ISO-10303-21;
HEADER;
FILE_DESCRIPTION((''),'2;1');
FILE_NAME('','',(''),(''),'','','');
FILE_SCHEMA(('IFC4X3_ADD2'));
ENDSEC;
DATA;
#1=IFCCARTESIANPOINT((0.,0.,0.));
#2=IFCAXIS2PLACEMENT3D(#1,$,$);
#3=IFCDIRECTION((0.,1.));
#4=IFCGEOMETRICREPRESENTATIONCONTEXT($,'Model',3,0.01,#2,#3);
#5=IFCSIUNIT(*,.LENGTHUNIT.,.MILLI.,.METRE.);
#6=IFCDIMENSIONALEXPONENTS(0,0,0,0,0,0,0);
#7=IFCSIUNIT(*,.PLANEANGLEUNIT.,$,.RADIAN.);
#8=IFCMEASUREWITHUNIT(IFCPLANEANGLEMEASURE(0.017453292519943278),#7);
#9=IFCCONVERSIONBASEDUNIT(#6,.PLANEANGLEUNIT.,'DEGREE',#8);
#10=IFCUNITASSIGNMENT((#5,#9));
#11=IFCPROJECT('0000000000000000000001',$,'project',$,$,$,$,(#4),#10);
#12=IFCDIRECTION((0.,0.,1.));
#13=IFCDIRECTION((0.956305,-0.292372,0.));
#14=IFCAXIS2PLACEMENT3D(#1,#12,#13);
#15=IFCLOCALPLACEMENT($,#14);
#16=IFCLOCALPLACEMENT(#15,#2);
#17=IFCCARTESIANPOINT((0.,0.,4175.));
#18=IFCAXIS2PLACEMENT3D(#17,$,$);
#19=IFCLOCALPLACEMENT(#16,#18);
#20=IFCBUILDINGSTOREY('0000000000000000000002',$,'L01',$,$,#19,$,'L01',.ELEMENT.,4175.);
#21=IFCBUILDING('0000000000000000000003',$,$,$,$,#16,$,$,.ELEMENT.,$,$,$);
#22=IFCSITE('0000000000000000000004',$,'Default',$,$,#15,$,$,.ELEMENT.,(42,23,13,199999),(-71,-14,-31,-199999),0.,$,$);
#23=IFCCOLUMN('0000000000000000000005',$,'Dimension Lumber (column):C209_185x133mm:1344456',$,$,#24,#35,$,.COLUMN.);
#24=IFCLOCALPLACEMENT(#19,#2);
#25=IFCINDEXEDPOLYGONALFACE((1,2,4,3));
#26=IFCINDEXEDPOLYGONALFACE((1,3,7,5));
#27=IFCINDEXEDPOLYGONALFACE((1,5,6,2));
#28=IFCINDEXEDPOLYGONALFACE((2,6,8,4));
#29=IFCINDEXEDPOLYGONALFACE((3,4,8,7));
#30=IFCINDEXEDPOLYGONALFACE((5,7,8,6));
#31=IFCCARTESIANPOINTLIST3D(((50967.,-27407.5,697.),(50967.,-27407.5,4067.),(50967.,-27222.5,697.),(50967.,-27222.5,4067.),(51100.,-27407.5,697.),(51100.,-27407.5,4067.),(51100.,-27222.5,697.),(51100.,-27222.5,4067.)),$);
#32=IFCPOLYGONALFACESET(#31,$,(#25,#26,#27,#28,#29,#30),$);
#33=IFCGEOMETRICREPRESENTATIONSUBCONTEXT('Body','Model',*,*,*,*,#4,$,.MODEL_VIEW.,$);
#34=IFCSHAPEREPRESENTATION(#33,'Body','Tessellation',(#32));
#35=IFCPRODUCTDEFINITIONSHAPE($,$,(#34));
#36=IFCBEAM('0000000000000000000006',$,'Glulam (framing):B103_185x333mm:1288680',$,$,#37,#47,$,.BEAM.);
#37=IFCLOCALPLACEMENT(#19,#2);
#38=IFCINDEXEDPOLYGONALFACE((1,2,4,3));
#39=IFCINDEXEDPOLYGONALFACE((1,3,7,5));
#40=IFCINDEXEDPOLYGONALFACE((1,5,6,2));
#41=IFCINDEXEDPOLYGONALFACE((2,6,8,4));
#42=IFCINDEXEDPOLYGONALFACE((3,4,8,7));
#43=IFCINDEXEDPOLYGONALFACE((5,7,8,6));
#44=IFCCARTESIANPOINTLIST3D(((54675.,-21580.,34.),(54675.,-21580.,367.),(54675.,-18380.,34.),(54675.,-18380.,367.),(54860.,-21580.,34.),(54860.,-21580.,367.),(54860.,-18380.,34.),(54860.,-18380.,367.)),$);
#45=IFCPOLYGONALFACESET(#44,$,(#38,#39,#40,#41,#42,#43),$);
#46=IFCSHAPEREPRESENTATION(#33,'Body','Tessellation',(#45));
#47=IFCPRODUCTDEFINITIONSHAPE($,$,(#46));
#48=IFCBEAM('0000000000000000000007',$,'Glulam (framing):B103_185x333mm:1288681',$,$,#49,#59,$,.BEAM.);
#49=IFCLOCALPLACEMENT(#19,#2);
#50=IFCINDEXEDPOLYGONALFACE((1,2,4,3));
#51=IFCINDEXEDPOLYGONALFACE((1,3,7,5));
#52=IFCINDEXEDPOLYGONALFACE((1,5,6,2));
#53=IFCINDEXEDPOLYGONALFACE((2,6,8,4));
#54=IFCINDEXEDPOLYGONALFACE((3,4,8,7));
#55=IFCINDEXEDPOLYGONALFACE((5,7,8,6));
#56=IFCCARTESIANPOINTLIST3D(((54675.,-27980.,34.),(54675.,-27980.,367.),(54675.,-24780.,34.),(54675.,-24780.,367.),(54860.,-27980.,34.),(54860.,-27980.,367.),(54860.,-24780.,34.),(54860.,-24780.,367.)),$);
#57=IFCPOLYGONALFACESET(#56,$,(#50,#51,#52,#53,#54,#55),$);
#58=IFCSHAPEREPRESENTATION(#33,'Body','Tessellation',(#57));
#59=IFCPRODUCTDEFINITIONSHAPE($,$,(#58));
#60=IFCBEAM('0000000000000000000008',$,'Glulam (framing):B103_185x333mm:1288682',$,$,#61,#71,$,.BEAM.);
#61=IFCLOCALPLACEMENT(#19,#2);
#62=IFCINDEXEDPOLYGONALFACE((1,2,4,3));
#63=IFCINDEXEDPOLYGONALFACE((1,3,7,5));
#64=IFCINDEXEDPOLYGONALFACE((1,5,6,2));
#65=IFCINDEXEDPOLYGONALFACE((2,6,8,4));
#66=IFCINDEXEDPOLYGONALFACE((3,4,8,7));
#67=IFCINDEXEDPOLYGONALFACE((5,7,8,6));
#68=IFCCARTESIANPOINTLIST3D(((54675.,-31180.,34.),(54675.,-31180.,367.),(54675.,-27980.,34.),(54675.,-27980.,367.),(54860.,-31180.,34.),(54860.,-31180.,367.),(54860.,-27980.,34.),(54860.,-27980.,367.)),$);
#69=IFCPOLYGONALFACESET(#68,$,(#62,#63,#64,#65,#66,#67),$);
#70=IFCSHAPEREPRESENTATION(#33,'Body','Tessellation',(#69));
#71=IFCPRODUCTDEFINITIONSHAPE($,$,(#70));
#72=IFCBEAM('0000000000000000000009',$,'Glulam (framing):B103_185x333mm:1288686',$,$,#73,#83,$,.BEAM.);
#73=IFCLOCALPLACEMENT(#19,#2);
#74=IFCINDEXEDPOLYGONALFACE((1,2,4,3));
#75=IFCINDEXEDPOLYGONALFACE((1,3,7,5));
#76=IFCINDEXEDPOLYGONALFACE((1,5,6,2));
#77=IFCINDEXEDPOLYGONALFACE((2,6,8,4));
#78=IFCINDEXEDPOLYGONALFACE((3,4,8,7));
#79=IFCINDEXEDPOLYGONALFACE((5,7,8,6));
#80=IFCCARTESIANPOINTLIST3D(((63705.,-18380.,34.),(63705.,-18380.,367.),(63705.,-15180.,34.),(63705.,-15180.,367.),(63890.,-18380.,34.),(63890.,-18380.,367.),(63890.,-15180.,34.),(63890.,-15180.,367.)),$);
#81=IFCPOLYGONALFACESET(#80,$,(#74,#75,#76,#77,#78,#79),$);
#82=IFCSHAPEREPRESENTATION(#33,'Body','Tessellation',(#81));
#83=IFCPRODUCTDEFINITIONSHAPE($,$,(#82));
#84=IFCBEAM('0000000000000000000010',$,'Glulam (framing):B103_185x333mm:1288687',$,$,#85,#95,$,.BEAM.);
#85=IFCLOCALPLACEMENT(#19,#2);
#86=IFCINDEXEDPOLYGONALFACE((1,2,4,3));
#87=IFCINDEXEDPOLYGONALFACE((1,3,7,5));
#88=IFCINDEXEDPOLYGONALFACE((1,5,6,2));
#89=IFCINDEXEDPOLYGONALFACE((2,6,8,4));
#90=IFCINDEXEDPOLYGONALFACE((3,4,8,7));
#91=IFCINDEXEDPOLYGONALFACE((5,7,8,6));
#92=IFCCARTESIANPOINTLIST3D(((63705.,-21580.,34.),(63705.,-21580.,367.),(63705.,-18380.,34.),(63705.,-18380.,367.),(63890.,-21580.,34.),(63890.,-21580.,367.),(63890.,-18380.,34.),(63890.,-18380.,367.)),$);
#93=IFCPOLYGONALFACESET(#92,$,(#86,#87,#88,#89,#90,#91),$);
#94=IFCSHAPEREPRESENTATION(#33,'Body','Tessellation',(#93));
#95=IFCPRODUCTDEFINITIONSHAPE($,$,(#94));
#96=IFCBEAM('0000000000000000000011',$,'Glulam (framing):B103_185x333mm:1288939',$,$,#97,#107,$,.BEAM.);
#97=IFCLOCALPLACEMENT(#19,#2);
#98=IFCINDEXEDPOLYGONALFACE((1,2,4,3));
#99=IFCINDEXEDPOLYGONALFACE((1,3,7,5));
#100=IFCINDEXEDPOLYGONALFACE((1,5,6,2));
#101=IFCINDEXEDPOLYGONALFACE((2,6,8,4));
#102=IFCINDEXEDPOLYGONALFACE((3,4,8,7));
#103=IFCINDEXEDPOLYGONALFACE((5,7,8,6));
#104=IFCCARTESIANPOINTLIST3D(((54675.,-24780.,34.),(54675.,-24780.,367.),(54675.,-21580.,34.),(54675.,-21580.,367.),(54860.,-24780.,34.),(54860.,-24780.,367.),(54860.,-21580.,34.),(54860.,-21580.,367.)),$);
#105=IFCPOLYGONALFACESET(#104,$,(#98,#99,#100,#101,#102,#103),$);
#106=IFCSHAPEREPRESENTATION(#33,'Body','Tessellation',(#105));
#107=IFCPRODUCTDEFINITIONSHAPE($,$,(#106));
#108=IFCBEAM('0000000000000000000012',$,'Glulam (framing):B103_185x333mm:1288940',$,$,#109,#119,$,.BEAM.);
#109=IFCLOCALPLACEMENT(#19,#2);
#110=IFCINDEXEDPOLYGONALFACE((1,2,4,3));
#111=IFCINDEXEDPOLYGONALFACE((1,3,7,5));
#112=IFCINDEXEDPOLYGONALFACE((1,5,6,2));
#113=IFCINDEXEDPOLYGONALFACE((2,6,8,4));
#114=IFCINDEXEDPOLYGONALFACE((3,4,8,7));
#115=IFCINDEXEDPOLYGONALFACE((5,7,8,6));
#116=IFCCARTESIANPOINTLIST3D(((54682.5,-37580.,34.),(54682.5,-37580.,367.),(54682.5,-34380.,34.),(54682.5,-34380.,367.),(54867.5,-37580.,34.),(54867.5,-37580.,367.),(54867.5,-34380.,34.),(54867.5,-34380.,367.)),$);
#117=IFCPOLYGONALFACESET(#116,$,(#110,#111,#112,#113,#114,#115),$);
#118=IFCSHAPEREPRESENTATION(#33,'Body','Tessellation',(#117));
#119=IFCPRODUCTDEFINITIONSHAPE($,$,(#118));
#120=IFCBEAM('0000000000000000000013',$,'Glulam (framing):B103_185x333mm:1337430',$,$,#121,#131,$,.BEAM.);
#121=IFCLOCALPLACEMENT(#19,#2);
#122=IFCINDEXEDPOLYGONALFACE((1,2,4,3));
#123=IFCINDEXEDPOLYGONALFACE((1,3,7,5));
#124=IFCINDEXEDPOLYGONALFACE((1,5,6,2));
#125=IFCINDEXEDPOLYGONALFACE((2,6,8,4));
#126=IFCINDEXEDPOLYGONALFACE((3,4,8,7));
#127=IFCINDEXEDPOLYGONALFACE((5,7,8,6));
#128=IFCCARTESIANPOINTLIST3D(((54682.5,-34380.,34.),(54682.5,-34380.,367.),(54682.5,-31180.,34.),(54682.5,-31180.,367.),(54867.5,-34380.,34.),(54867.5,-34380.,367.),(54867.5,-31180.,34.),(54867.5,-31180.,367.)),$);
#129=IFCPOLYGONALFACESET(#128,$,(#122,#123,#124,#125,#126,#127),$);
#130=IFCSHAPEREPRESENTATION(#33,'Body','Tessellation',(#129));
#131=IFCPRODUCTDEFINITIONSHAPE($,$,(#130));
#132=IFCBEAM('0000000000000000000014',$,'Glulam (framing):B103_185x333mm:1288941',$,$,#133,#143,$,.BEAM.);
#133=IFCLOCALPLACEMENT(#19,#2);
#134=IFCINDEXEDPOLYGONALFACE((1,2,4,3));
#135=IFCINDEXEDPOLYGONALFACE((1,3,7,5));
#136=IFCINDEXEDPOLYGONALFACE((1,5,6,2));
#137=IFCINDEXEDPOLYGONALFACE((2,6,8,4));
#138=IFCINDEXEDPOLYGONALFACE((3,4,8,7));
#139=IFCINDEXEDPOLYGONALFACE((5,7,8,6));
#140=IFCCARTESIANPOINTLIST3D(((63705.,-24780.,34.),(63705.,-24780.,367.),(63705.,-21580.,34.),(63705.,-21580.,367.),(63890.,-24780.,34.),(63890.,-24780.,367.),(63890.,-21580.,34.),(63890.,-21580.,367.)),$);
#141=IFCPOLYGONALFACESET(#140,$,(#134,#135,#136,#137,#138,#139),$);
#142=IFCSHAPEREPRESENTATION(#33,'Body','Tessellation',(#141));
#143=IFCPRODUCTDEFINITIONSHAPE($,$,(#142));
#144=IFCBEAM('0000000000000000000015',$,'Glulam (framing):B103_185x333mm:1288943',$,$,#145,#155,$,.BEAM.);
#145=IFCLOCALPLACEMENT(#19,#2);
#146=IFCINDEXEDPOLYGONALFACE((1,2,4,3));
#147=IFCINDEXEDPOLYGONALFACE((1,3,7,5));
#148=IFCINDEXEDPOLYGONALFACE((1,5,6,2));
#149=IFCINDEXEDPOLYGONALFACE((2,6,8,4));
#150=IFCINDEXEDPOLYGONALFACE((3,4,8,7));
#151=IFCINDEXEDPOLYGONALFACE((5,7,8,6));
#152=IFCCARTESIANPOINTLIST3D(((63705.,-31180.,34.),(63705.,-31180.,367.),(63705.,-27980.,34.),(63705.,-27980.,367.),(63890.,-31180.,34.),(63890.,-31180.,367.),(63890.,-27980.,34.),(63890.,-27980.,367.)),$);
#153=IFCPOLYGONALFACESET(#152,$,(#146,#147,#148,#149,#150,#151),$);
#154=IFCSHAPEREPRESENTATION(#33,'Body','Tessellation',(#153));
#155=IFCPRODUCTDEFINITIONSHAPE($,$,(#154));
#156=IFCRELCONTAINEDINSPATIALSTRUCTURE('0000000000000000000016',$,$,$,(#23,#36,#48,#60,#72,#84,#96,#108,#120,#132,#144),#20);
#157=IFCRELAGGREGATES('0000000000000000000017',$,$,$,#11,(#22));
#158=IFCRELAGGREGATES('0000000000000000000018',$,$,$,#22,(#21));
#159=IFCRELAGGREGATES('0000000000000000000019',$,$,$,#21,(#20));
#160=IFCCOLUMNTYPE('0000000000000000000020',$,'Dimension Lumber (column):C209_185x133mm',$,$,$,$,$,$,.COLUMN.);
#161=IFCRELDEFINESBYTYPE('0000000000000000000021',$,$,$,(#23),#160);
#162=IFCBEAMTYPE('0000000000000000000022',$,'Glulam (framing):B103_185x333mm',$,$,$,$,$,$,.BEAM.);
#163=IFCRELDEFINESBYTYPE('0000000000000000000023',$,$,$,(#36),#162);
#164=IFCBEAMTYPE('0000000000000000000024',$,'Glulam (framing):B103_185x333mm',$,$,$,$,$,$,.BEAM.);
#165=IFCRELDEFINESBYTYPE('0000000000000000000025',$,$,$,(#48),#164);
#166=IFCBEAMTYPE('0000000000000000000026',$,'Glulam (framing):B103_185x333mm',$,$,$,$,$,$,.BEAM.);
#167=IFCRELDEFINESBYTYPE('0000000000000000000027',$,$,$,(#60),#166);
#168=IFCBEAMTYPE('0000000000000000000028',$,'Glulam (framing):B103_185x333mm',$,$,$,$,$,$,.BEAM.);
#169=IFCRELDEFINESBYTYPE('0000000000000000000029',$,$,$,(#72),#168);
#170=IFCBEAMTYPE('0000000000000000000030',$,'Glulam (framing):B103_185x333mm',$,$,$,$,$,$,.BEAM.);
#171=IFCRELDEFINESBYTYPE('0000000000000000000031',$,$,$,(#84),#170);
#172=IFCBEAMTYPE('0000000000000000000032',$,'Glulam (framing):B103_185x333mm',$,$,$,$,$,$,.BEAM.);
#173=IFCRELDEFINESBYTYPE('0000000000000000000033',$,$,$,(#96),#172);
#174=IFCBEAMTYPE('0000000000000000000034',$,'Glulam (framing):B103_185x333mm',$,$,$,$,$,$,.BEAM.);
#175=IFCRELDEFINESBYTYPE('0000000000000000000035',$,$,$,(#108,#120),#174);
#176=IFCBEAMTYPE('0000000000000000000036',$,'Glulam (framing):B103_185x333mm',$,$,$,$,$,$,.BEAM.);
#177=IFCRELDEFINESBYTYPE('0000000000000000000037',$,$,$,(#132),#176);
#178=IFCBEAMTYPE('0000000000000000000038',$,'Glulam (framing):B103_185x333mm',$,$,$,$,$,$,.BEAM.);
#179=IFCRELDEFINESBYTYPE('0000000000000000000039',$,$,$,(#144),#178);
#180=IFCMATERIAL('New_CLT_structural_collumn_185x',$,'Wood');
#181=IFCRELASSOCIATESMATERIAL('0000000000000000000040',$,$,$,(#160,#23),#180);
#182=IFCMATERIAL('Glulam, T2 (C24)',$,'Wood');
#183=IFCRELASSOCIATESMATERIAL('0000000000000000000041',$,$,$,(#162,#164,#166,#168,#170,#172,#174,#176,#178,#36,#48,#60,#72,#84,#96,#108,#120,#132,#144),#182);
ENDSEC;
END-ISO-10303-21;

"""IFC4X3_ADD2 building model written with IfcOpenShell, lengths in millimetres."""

from ifc_helpers import new_model, entity, si_unit, converted_unit, direction, frame, origin, origin_2d_with_axis, place, context, subcontext, project, spatial, rectangle, extrude, source, transform, mapped, material, material_profile, profile_set, profile_usage, type_object, type_shapes, element, save


model = new_model("IFC4X3_ADD2")

# Units and contexts
model_context = context("Model", 3, precision=0.01, world=origin(), true_north=direction((0.0, 1.0)))
body_context = subcontext(model_context, "Body", "Model", "MODEL_VIEW")
ifc_project = project(units=[si_unit("LENGTHUNIT", "METRE", prefix="MILLI"), converted_unit("PLANEANGLEUNIT", "DEGREE", entity("IfcPlaneAngleMeasure", 0.017453292519943278), si_unit("PLANEANGLEUNIT", "RADIAN"), dimensions=[0, 0, 0, 0, 0, 0, 0])], contexts=[model_context])

# Site, building, storey
site_placement = place(None, frame((0.0, 0.0, 0.0), z_axis=(0.0, 0.0, 1.0), x_axis=(0.956305, -0.292372, 0.0)))
site = spatial("IfcSite", under=ifc_project, at=site_placement, Name="Default", CompositionType="ELEMENT", RefLatitude=(42, 23, 13, 199999), RefLongitude=(-71, -14, -31, -199999), RefElevation=0.0)
building_placement = place(site_placement, origin())
building = spatial("IfcBuilding", under=site, at=building_placement, CompositionType="ELEMENT")
storey_placement = place(building_placement, frame((0.0, 0.0, 4175.0)))
storey = spatial("IfcBuildingStorey", under=building, at=storey_placement, Name="L01", LongName="L01", CompositionType="ELEMENT", Elevation=4175.0)

# Column
ifc_material_1 = material(Name="New_CLT_structural_collumn_185x", Category="Wood")
ifc_material_profile_1 = material_profile(ifc_material_1, rectangle(XDim=185.0, YDim=133.0, at=origin_2d_with_axis()), Name="C209_185x133mm")
ifc_profile_set_1 = profile_set([ifc_material_profile_1], Name="C209_185x133mm")
ifc_profile_usage_1 = profile_usage(ifc_profile_set_1)
column_type_1 = type_object("IfcColumnType", Name="Dimension Lumber (column):C209_185x133mm", PredefinedType="COLUMN", material=ifc_profile_set_1)
shared_shape_1 = source(origin(), body_context, "Body", "SweptSolid", [
    extrude(rectangle(XDim=185.0, YDim=133.0, at=origin_2d_with_axis()), frame((0.0, 0.0, 4872.0), z_axis=(0.0, 0.0, 1.0), x_axis=(-1.0, 0.0, 0.0)), (0.0, 0.0, 1.0), 3370.0),
])
type_shapes(column_type_1, [shared_shape_1])
column_placement = place(storey_placement, frame((51033.5, -27315.0, -4175.0), z_axis=(0.0, 0.0, 1.0), x_axis=(0.0, 1.0, 0.0)))
element("IfcColumn", 1, at=column_placement, inside=storey, type_object=column_type_1, material=ifc_profile_usage_1, Name="Dimension Lumber (column):C209_185x133mm:1344456", PredefinedType="COLUMN", context=body_context, shape_type="MappedRepresentation", body=[
    mapped(shared_shape_1, transform((0.0, 0.0, 0.0), scale=1.0)),
])

# Beams
ifc_material_2 = material(Name="Glulam, T2 (C24)", Category="Wood")
ifc_material_profile_2 = material_profile(ifc_material_2, rectangle(XDim=3200.0, YDim=185.0, at=origin_2d_with_axis()), Name="B103_185x333mm")
ifc_profile_set_2 = profile_set([ifc_material_profile_2], Name="B103_185x333mm")
ifc_profile_usage_2 = profile_usage(ifc_profile_set_2, cardinal=8)
beam_type_1 = type_object("IfcBeamType", Name="Glulam (framing):B103_185x333mm", PredefinedType="BEAM", material=ifc_profile_set_2)
shared_shape_2 = source(origin(), body_context, "Body", "SweptSolid", [
    extrude(rectangle(XDim=3200.0, YDim=185.0, at=origin_2d_with_axis()), frame((0.0, 0.0, -166.5), z_axis=(0.0, 0.0, 1.0), x_axis=(-1.0, 0.0, 0.0)), (0.0, 0.0, 1.0), 333.0),
])
type_shapes(beam_type_1, [shared_shape_2])
beam_1_placement = place(storey_placement, frame((54767.5, -19980.0, 200.5), z_axis=(0.0, 0.0, 1.0), x_axis=(0.0, -1.0, 0.0)))
element("IfcBeam", 2, at=beam_1_placement, inside=storey, type_object=beam_type_1, material=ifc_profile_usage_2, Name="Glulam (framing):B103_185x333mm:1288680", PredefinedType="BEAM", context=body_context, shape_type="MappedRepresentation", body=[
    mapped(shared_shape_2, transform((0.0, 0.0, 0.0), scale=1.0)),
])
beam_type_2 = type_object("IfcBeamType", Name="Glulam (framing):B103_185x333mm", PredefinedType="BEAM", material=ifc_profile_set_2)
shared_shape_3 = source(origin(), body_context, "Body", "SweptSolid", [
    extrude(rectangle(XDim=3200.0, YDim=185.0, at=origin_2d_with_axis()), frame((0.0, 0.0, -166.5), z_axis=(0.0, 0.0, 1.0), x_axis=(-1.0, 0.0, 0.0)), (0.0, 0.0, 1.0), 333.0),
])
type_shapes(beam_type_2, [shared_shape_3])
beam_2_placement = place(storey_placement, frame((54767.5, -26380.0, 200.5), z_axis=(0.0, 0.0, 1.0), x_axis=(0.0, -1.0, 0.0)))
element("IfcBeam", 3, at=beam_2_placement, inside=storey, type_object=beam_type_2, material=ifc_profile_usage_2, Name="Glulam (framing):B103_185x333mm:1288681", PredefinedType="BEAM", context=body_context, shape_type="MappedRepresentation", body=[
    mapped(shared_shape_3, transform((0.0, 0.0, 0.0), scale=1.0)),
])
beam_type_3 = type_object("IfcBeamType", Name="Glulam (framing):B103_185x333mm", PredefinedType="BEAM", material=ifc_profile_set_2)
shared_shape_4 = source(origin(), body_context, "Body", "SweptSolid", [
    extrude(rectangle(XDim=3200.0, YDim=185.0, at=origin_2d_with_axis()), frame((0.0, 0.0, -166.5), z_axis=(0.0, 0.0, 1.0), x_axis=(-1.0, 0.0, 0.0)), (0.0, 0.0, 1.0), 333.0),
])
type_shapes(beam_type_3, [shared_shape_4])
beam_3_placement = place(storey_placement, frame((54767.5, -29580.0, 200.5), z_axis=(0.0, 0.0, 1.0), x_axis=(0.0, -1.0, 0.0)))
element("IfcBeam", 4, at=beam_3_placement, inside=storey, type_object=beam_type_3, material=ifc_profile_usage_2, Name="Glulam (framing):B103_185x333mm:1288682", PredefinedType="BEAM", context=body_context, shape_type="MappedRepresentation", body=[
    mapped(shared_shape_4, transform((0.0, 0.0, 0.0), scale=1.0)),
])
beam_type_4 = type_object("IfcBeamType", Name="Glulam (framing):B103_185x333mm", PredefinedType="BEAM", material=ifc_profile_set_2)
shared_shape_5 = source(origin(), body_context, "Body", "SweptSolid", [
    extrude(rectangle(XDim=185.0, YDim=3200.0, at=origin_2d_with_axis()), frame((0.0, 0.0, -166.5), z_axis=(0.0, 0.0, 1.0), x_axis=(0.0, 1.0, 0.0)), (0.0, 0.0, 1.0), 333.0),
])
type_shapes(beam_type_4, [shared_shape_5])
beam_4_placement = place(storey_placement, frame((63797.5, -16780.0, 200.5), z_axis=(0.0, 0.0, 1.0), x_axis=(0.0, -1.0, 0.0)))
element("IfcBeam", 5, at=beam_4_placement, inside=storey, type_object=beam_type_4, material=ifc_profile_usage_2, Name="Glulam (framing):B103_185x333mm:1288686", PredefinedType="BEAM", context=body_context, shape_type="MappedRepresentation", body=[
    mapped(shared_shape_5, transform((0.0, 0.0, 0.0), scale=1.0)),
])
beam_type_5 = type_object("IfcBeamType", Name="Glulam (framing):B103_185x333mm", PredefinedType="BEAM", material=ifc_profile_set_2)
shared_shape_6 = source(origin(), body_context, "Body", "SweptSolid", [
    extrude(rectangle(XDim=185.0, YDim=3200.0, at=origin_2d_with_axis()), frame((0.0, 0.0, -166.5), z_axis=(0.0, 0.0, 1.0), x_axis=(0.0, 1.0, 0.0)), (0.0, 0.0, 1.0), 333.0),
])
type_shapes(beam_type_5, [shared_shape_6])
beam_5_placement = place(storey_placement, frame((63797.5, -19980.0, 200.5), z_axis=(0.0, 0.0, 1.0), x_axis=(0.0, -1.0, 0.0)))
element("IfcBeam", 6, at=beam_5_placement, inside=storey, type_object=beam_type_5, material=ifc_profile_usage_2, Name="Glulam (framing):B103_185x333mm:1288687", PredefinedType="BEAM", context=body_context, shape_type="MappedRepresentation", body=[
    mapped(shared_shape_6, transform((0.0, 0.0, 0.0), scale=1.0)),
])
beam_type_6 = type_object("IfcBeamType", Name="Glulam (framing):B103_185x333mm", PredefinedType="BEAM", material=ifc_profile_set_2)
shared_shape_7 = source(origin(), body_context, "Body", "SweptSolid", [
    extrude(rectangle(XDim=3200.0, YDim=185.0, at=origin_2d_with_axis()), frame((0.0, 0.0, -166.5), z_axis=(0.0, 0.0, 1.0), x_axis=(-1.0, 0.0, 0.0)), (0.0, 0.0, 1.0), 333.0),
])
type_shapes(beam_type_6, [shared_shape_7])
beam_6_placement = place(storey_placement, frame((54767.5, -23180.0, 200.5), z_axis=(0.0, 0.0, 1.0), x_axis=(0.0, -1.0, 0.0)))
element("IfcBeam", 7, at=beam_6_placement, inside=storey, type_object=beam_type_6, material=ifc_profile_usage_2, Name="Glulam (framing):B103_185x333mm:1288939", PredefinedType="BEAM", context=body_context, shape_type="MappedRepresentation", body=[
    mapped(shared_shape_7, transform((0.0, 0.0, 0.0), scale=1.0)),
])
beam_type_7 = type_object("IfcBeamType", Name="Glulam (framing):B103_185x333mm", PredefinedType="BEAM", material=ifc_profile_set_2)
shared_shape_8 = source(origin(), body_context, "Body", "SweptSolid", [
    extrude(rectangle(XDim=3200.0, YDim=185.0, at=origin_2d_with_axis()), frame((548.0, 0.0, -166.5), z_axis=(0.0, 0.0, 1.0), x_axis=(-1.0, 0.0, 0.0)), (0.0, 0.0, 1.0), 333.0),
])
type_shapes(beam_type_7, [shared_shape_8])
for number, where, z_axis, x_axis, name in (
    (8, (54775.0, -35432.0, 200.5), (0.0, 0.0, 1.0), (0.0, -1.0, 0.0), "Glulam (framing):B103_185x333mm:1288940"),
    (9, (54775.0, -32232.0, 200.5), (0.0, 0.0, 1.0), (0.0, -1.0, 0.0), "Glulam (framing):B103_185x333mm:1337430"),
):
    element("IfcBeam", number, at=place(storey_placement, frame(where, z_axis=z_axis, x_axis=x_axis)), inside=storey, type_object=beam_type_7, material=ifc_profile_usage_2, Name=name, PredefinedType="BEAM", context=body_context, shape_type="MappedRepresentation", body=[
        mapped(shared_shape_8, transform((0.0, 0.0, 0.0), scale=1.0)),
    ])
beam_type_8 = type_object("IfcBeamType", Name="Glulam (framing):B103_185x333mm", PredefinedType="BEAM", material=ifc_profile_set_2)
shared_shape_9 = source(origin(), body_context, "Body", "SweptSolid", [
    extrude(rectangle(XDim=185.0, YDim=3200.0, at=origin_2d_with_axis()), frame((0.0, 0.0, -166.5), z_axis=(0.0, 0.0, 1.0), x_axis=(0.0, 1.0, 0.0)), (0.0, 0.0, 1.0), 333.0),
])
type_shapes(beam_type_8, [shared_shape_9])
beam_7_placement = place(storey_placement, frame((63797.5, -23180.0, 200.5), z_axis=(0.0, 0.0, 1.0), x_axis=(0.0, -1.0, 0.0)))
element("IfcBeam", 10, at=beam_7_placement, inside=storey, type_object=beam_type_8, material=ifc_profile_usage_2, Name="Glulam (framing):B103_185x333mm:1288941", PredefinedType="BEAM", context=body_context, shape_type="MappedRepresentation", body=[
    mapped(shared_shape_9, transform((0.0, 0.0, 0.0), scale=1.0)),
])
beam_type_9 = type_object("IfcBeamType", Name="Glulam (framing):B103_185x333mm", PredefinedType="BEAM", material=ifc_profile_set_2)
shared_shape_10 = source(origin(), body_context, "Body", "SweptSolid", [
    extrude(rectangle(XDim=185.0, YDim=3200.0, at=origin_2d_with_axis()), frame((0.0, 0.0, -166.5), z_axis=(0.0, 0.0, 1.0), x_axis=(0.0, 1.0, 0.0)), (0.0, 0.0, 1.0), 333.0),
])
type_shapes(beam_type_9, [shared_shape_10])
beam_8_placement = place(storey_placement, frame((63797.5, -29580.0, 200.5), z_axis=(0.0, 0.0, 1.0), x_axis=(0.0, -1.0, 0.0)))
element("IfcBeam", 11, at=beam_8_placement, inside=storey, type_object=beam_type_9, material=ifc_profile_usage_2, Name="Glulam (framing):B103_185x333mm:1288943", PredefinedType="BEAM", context=body_context, shape_type="MappedRepresentation", body=[
    mapped(shared_shape_10, transform((0.0, 0.0, 0.0), scale=1.0)),
])

save(model, "model.ifc")
